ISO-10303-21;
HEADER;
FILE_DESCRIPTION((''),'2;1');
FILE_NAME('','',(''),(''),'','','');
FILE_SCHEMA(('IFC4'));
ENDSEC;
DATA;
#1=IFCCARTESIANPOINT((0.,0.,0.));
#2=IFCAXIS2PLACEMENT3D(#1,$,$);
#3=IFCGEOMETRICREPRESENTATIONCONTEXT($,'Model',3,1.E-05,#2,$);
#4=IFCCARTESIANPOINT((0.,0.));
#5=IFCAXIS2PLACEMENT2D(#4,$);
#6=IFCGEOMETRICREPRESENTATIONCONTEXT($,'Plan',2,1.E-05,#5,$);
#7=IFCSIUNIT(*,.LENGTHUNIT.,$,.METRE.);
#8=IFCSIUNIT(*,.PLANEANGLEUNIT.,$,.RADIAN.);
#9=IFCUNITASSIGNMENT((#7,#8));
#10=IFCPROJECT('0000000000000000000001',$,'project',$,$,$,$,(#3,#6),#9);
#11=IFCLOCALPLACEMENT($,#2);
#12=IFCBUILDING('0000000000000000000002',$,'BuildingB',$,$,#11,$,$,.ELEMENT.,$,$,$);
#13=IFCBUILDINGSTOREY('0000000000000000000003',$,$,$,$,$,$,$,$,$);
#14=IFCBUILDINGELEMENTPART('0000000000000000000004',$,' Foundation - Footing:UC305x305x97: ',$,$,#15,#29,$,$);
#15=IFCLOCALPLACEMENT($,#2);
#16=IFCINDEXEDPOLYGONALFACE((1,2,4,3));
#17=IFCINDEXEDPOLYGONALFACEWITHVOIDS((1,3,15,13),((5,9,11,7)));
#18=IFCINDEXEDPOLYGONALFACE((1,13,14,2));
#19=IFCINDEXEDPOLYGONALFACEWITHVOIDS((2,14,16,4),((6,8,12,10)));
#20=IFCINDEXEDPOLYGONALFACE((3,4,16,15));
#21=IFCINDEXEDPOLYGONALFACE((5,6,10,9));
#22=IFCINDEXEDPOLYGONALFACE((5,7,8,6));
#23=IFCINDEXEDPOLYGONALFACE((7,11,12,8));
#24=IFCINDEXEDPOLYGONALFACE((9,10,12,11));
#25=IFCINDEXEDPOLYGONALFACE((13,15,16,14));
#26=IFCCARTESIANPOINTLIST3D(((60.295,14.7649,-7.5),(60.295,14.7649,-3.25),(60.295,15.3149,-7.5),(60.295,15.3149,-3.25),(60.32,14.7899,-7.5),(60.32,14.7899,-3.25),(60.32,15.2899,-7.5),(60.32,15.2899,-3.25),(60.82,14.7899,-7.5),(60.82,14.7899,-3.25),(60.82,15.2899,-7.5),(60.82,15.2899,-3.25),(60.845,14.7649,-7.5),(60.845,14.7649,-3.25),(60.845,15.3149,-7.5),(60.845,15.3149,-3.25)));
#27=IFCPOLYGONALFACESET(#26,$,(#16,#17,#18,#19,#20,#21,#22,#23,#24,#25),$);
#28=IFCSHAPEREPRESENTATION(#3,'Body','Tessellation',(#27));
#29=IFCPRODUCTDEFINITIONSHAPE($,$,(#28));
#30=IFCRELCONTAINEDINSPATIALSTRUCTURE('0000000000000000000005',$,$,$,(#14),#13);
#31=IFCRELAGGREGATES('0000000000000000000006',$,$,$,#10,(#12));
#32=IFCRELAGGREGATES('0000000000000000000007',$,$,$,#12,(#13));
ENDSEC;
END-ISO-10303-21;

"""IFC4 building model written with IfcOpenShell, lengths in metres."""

from ifc_helpers import new_model, si_unit, origin, origin_2d, place, context, project, spatial, polyline, outline, extrude, element, save


model = new_model("IFC4")

# Units and contexts
model_context = context("Model", 3, precision=1e-05, world=origin())
plan_context = context("Plan", 2, precision=1e-05, world=origin_2d())
ifc_project = project(units=[si_unit("LENGTHUNIT", "METRE"), si_unit("PLANEANGLEUNIT", "RADIAN")], contexts=[model_context, plan_context])

# Building, storey
building_placement = place(None, origin())
building = spatial("IfcBuilding", under=ifc_project, at=building_placement, Name="BuildingB", CompositionType="ELEMENT")
storey = spatial("IfcBuildingStorey", under=building)

# Building element part, opening
building_element_part_1 = element("IfcBuildingElementPart", 1, inside=storey, Name=" Foundation - Footing:UC305x305x97: ", context=model_context, shape_type="SweptSolid", body=[
    extrude(outline(polyline([(60.845, 15.3149, -7.5), (60.295, 15.3149, -7.5), (60.295, 14.7649, -7.5), (60.845, 14.7649, -7.5), (60.845, 15.3149, -7.5)])), None, (0.0, 0.0, 1.0), 4.25),
])
element("IfcOpeningElement", 2, inside=storey, cuts=building_element_part_1, context=model_context, shape_type="SweptSolid", body=[
    extrude(outline(polyline([(60.82, 15.2899, -7.5), (60.32, 15.2899, -7.5), (60.32, 14.7899, -7.5), (60.82, 14.7899, -7.5), (60.82, 15.2899, -7.5)])), None, (0.0, 0.0, 1.0), 4.25),
])

save(model, "model.ifc")
